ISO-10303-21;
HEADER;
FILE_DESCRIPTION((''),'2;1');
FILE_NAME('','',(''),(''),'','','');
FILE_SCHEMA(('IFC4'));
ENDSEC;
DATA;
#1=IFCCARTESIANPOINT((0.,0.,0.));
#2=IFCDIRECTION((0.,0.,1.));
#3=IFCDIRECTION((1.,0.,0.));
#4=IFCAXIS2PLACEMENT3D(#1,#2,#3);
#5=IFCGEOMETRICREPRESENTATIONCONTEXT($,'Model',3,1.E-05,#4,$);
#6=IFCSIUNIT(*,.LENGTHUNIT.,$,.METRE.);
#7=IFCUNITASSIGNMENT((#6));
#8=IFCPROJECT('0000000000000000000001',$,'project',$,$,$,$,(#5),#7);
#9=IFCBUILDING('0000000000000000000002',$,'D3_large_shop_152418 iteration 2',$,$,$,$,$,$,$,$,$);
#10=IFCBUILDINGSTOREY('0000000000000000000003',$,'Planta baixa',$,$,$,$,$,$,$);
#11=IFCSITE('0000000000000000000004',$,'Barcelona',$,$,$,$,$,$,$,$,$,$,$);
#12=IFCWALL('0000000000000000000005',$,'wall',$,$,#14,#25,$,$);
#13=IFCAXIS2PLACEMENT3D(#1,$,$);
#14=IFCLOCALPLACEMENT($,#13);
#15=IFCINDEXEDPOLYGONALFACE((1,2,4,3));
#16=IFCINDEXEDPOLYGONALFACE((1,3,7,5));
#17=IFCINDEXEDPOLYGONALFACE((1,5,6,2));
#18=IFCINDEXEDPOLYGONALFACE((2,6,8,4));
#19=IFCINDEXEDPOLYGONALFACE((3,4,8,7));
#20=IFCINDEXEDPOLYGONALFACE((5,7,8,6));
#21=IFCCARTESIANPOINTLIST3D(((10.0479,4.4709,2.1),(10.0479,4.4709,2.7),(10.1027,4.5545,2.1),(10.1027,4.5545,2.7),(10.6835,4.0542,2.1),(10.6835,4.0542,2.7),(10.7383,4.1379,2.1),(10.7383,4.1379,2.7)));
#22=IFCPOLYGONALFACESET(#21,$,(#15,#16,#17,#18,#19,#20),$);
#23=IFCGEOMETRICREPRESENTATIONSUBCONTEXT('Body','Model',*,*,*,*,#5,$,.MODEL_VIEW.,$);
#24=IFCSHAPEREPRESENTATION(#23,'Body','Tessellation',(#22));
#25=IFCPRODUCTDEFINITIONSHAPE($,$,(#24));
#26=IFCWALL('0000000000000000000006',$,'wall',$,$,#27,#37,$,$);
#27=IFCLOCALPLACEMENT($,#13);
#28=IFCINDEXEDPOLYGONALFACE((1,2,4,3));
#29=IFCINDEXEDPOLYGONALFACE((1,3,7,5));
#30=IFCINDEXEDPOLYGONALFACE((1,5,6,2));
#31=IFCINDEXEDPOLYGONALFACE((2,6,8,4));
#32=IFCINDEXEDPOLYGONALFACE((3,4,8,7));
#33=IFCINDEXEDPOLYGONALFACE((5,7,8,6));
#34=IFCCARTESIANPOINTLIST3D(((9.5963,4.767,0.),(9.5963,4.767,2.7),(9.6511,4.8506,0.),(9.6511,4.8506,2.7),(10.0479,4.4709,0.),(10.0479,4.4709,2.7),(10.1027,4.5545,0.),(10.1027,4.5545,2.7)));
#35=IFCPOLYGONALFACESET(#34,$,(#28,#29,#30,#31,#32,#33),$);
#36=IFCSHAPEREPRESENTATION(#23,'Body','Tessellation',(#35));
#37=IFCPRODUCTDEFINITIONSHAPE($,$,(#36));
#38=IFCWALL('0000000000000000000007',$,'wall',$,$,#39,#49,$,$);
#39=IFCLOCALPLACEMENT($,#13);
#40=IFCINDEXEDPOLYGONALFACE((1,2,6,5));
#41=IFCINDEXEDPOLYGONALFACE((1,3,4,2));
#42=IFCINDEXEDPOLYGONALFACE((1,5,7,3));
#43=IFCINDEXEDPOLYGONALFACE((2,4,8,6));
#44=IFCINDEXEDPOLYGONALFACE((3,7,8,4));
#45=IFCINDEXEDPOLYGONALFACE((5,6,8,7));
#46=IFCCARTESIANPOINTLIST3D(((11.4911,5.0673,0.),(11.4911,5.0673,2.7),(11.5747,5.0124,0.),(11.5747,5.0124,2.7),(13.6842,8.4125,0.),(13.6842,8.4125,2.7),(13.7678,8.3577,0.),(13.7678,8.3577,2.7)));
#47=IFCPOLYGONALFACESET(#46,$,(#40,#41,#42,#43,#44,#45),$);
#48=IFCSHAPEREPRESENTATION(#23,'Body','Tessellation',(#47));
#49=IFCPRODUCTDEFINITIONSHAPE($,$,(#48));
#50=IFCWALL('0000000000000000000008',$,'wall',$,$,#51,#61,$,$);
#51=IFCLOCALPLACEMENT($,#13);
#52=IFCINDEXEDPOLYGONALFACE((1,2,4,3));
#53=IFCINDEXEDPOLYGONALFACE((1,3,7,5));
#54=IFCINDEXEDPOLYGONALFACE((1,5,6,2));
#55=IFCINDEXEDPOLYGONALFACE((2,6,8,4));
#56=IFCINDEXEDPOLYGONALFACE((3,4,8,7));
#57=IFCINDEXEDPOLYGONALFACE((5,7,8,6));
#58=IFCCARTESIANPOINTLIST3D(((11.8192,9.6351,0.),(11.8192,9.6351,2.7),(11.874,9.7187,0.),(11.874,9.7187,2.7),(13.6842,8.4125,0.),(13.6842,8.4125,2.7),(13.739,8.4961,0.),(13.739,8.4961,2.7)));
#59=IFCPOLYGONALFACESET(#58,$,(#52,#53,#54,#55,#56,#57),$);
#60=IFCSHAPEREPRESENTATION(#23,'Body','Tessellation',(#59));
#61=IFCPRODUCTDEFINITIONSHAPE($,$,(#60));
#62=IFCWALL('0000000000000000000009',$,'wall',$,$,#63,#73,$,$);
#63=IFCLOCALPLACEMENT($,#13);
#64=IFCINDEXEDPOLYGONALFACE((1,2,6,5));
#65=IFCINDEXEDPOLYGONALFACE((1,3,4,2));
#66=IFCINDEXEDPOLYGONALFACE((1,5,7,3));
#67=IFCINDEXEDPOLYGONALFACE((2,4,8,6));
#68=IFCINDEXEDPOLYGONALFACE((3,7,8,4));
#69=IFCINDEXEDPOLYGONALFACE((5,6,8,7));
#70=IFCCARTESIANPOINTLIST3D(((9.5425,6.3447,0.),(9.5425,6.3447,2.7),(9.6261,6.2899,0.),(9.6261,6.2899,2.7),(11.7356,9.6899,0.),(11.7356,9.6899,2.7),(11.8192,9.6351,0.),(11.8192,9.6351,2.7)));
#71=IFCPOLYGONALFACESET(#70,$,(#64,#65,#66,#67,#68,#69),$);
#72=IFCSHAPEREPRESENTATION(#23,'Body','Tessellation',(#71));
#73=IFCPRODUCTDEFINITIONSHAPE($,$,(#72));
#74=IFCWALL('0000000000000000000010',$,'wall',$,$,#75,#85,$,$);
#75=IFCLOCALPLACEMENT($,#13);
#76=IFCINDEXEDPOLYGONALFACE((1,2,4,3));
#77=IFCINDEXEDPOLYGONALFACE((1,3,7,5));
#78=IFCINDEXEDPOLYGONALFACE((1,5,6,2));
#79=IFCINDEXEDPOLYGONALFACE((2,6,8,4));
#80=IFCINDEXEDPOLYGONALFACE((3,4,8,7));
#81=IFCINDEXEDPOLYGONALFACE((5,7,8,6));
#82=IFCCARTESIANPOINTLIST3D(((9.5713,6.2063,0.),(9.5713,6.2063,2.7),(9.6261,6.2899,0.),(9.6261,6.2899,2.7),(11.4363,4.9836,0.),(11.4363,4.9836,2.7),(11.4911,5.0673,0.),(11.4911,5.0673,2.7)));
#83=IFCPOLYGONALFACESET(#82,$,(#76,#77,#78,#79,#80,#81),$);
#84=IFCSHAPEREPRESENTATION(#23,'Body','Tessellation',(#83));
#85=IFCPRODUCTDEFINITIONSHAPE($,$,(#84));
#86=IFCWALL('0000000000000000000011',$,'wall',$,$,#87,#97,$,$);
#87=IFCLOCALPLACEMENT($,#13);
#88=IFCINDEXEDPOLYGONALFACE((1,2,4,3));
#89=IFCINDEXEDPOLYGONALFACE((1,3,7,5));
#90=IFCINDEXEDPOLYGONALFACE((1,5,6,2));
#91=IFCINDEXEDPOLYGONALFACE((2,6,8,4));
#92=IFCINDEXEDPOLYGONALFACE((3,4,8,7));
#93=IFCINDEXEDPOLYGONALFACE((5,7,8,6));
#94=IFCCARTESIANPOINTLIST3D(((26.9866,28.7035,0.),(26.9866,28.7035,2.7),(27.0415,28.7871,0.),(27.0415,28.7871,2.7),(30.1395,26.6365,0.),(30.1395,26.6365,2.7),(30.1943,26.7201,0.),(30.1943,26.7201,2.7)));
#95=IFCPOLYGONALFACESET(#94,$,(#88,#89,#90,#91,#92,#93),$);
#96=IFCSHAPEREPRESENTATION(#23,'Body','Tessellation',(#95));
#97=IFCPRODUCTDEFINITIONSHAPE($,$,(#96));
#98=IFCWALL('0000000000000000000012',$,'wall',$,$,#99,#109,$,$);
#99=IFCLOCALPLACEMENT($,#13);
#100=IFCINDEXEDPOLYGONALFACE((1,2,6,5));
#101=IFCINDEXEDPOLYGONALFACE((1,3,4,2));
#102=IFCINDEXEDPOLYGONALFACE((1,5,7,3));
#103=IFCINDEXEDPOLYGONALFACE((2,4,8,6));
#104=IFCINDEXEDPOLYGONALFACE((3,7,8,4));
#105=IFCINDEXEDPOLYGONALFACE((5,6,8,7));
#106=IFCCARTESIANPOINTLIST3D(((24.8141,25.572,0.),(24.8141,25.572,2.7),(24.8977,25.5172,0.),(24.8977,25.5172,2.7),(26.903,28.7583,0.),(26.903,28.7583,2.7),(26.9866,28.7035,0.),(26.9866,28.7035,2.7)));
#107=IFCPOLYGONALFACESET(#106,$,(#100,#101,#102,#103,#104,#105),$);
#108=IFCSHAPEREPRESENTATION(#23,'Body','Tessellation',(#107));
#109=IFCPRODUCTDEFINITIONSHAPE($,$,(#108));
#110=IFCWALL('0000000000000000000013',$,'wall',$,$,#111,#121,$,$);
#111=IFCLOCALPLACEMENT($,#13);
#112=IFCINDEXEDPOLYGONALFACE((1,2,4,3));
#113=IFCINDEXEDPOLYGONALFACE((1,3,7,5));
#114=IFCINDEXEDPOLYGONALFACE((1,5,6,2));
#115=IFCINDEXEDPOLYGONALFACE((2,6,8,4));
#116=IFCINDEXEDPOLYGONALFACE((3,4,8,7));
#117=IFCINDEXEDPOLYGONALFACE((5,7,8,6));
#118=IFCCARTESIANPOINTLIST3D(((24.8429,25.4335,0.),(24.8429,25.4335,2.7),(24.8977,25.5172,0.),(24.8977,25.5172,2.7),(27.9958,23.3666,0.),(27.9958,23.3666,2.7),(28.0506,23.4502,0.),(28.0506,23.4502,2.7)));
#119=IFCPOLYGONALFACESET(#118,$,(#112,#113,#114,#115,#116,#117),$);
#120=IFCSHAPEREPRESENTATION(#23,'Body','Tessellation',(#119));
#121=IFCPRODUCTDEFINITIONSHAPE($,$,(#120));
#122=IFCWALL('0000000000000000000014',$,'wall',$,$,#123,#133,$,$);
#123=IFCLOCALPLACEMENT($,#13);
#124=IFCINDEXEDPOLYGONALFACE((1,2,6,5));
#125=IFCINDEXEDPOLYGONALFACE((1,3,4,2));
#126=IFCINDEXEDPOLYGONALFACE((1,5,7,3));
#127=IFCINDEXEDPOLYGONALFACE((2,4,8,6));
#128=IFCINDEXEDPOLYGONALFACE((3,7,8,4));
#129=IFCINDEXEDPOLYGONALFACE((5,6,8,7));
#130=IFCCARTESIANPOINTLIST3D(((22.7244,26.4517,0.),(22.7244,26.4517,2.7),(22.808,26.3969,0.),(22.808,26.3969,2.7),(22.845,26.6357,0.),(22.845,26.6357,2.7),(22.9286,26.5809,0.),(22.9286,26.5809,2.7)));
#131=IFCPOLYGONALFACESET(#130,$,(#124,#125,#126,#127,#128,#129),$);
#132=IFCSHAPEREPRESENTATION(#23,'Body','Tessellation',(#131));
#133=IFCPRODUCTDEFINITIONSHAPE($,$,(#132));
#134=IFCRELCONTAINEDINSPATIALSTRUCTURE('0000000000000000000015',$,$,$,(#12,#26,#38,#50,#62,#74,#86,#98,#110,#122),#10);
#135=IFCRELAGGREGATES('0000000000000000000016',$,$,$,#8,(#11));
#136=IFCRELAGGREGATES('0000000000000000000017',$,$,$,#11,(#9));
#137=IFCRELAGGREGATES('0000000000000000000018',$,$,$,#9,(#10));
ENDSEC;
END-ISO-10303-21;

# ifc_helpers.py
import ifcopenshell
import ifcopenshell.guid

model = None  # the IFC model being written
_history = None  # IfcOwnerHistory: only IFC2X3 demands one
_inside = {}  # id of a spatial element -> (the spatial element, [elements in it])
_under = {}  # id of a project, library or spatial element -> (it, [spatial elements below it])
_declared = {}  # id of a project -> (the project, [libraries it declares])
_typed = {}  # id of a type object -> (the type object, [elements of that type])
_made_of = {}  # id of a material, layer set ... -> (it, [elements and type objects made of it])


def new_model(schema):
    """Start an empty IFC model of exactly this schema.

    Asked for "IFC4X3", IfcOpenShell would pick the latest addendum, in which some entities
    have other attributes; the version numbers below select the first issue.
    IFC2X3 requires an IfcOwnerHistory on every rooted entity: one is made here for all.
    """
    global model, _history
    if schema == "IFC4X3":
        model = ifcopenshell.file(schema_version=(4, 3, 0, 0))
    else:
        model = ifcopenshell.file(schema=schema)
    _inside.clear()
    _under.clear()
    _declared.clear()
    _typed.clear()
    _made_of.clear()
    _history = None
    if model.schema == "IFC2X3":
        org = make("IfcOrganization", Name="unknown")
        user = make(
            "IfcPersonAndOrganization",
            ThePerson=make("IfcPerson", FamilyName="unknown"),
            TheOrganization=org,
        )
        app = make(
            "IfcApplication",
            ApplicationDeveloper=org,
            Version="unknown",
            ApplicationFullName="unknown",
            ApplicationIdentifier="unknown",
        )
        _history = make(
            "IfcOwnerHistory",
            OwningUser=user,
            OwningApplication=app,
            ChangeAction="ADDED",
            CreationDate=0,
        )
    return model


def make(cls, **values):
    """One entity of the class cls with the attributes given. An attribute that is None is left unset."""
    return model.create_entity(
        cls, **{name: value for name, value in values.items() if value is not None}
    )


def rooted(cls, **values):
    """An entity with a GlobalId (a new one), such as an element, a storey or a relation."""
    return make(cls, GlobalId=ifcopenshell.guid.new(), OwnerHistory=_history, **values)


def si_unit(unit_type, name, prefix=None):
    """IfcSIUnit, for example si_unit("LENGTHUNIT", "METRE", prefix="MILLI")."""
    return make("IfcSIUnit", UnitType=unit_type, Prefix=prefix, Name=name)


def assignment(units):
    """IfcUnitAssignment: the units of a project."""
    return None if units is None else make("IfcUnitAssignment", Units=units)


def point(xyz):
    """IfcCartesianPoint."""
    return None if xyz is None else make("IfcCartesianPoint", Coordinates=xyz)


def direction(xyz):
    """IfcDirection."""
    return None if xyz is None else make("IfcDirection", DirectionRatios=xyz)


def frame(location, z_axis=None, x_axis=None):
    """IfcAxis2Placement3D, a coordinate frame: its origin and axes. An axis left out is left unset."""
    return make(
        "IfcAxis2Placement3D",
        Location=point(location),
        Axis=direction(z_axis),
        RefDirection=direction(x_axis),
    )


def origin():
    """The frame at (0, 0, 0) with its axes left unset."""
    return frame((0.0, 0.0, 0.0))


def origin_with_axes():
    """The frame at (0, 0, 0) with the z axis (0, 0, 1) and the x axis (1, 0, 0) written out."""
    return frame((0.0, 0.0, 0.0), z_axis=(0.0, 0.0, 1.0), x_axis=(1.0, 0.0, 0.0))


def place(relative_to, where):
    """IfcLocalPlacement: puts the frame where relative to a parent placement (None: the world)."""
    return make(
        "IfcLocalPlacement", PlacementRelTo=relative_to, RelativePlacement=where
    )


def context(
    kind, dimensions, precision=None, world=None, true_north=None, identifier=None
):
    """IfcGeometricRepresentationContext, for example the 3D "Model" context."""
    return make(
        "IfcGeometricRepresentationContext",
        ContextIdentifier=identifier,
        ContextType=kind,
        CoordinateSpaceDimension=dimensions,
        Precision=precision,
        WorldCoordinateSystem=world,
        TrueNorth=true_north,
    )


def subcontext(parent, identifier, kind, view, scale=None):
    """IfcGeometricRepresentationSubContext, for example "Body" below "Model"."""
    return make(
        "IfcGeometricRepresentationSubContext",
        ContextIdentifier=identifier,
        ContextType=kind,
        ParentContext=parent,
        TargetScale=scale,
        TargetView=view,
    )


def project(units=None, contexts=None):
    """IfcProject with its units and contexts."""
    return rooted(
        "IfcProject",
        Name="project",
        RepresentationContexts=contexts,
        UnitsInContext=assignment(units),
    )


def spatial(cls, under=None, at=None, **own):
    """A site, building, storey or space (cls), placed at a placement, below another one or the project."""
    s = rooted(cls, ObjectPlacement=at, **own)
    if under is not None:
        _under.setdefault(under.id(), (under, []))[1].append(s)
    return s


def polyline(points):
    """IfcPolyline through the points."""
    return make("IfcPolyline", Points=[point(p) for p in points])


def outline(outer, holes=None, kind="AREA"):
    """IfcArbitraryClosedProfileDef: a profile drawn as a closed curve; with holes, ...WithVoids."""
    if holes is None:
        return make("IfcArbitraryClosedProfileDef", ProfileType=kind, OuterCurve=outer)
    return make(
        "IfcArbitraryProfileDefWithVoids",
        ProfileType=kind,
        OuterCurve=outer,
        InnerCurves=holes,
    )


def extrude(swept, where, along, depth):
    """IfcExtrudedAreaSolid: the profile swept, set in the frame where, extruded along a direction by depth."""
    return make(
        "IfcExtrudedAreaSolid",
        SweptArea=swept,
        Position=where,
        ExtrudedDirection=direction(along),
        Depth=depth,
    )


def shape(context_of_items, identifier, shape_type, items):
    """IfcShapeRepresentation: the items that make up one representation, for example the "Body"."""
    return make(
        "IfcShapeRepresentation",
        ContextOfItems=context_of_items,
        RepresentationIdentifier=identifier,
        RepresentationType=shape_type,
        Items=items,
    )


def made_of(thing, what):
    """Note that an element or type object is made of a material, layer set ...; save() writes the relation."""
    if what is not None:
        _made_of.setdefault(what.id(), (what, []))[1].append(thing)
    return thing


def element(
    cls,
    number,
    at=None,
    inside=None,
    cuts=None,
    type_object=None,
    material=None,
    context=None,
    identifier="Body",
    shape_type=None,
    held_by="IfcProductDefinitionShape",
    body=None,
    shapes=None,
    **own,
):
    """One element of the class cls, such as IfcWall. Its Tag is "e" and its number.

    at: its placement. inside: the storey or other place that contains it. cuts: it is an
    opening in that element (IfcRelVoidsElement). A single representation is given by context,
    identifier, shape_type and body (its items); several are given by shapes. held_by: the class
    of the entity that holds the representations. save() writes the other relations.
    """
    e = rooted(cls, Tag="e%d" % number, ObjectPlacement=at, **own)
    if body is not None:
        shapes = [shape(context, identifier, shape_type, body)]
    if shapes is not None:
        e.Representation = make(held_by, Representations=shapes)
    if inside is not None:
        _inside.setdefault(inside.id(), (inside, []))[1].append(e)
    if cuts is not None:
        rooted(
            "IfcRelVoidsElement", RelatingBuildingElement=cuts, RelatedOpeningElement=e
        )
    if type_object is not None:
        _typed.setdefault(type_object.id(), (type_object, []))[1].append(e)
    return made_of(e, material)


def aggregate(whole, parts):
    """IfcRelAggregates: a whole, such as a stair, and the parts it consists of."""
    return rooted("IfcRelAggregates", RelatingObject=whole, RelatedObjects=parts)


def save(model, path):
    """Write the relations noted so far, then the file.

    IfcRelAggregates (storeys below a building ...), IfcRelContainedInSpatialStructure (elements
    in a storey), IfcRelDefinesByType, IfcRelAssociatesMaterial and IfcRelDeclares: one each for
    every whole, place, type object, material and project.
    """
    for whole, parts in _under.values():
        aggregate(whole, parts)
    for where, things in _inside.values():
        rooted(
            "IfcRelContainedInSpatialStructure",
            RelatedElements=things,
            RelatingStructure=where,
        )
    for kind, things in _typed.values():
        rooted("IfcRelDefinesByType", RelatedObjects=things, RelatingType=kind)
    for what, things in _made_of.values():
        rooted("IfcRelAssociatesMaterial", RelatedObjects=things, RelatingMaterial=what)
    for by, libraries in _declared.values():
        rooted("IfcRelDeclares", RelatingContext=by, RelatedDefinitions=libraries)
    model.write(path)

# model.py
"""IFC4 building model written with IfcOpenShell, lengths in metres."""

from ifc_helpers import new_model, si_unit, frame, origin, origin_with_axes, place, context, subcontext, project, spatial, polyline, outline, extrude, element, save


model = new_model("IFC4")

# Units and contexts
model_context = context("Model", 3, precision=1e-05, world=origin_with_axes())
body_context = subcontext(model_context, "Body", "Model", "MODEL_VIEW")
ifc_project = project(units=[si_unit("LENGTHUNIT", "METRE")], contexts=[model_context])

# Site, building, storey
site = spatial("IfcSite", under=ifc_project, Name="Barcelona")
building = spatial("IfcBuilding", under=site, Name="D3_large_shop_152418 iteration 2")
storey = spatial("IfcBuildingStorey", under=building, Name="Planta baixa")

# Walls
wall_1_placement = place(None, origin_with_axes())
element("IfcWall", 1, at=wall_1_placement, inside=storey, Name="wall", context=body_context, shape_type="SweptSolid", body=[
    extrude(outline(polyline([(10.6835, 4.0542), (10.0479, 4.4709), (10.1027, 4.5545), (10.7383, 4.1379), (10.6835, 4.0542)])), frame((0.0, 0.0, 2.1)), (0.0, 0.0, 1.0), 0.6),
])
wall_2_placement = place(None, origin_with_axes())
element("IfcWall", 2, at=wall_2_placement, inside=storey, Name="wall", context=body_context, shape_type="SweptSolid", body=[
    extrude(outline(polyline([(10.0479, 4.4709), (9.5963, 4.767), (9.6511, 4.8506), (10.1027, 4.5545), (10.0479, 4.4709)])), origin(), (0.0, 0.0, 1.0), 2.7),
])
wall_3_placement = place(None, origin_with_axes())
element("IfcWall", 3, at=wall_3_placement, inside=storey, Name="wall", context=body_context, shape_type="SweptSolid", body=[
    extrude(outline(polyline([(11.4911, 5.0673), (13.6842, 8.4125), (13.7678, 8.3577), (11.5747, 5.0124), (11.4911, 5.0673)])), origin(), (0.0, 0.0, 1.0), 2.7),
])
wall_4_placement = place(None, origin_with_axes())
element("IfcWall", 4, at=wall_4_placement, inside=storey, Name="wall", context=body_context, shape_type="SweptSolid", body=[
    extrude(outline(polyline([(13.6842, 8.4125), (11.8192, 9.6351), (11.874, 9.7187), (13.739, 8.4961), (13.6842, 8.4125)])), origin(), (0.0, 0.0, 1.0), 2.7),
])
wall_5_placement = place(None, origin_with_axes())
element("IfcWall", 5, at=wall_5_placement, inside=storey, Name="wall", context=body_context, shape_type="SweptSolid", body=[
    extrude(outline(polyline([(11.8192, 9.6351), (9.6261, 6.2899), (9.5425, 6.3447), (11.7356, 9.6899), (11.8192, 9.6351)])), origin(), (0.0, 0.0, 1.0), 2.7),
])
wall_6_placement = place(None, origin_with_axes())
element("IfcWall", 6, at=wall_6_placement, inside=storey, Name="wall", context=body_context, shape_type="SweptSolid", body=[
    extrude(outline(polyline([(9.6261, 6.2899), (11.4911, 5.0673), (11.4363, 4.9836), (9.5713, 6.2063), (9.6261, 6.2899)])), origin(), (0.0, 0.0, 1.0), 2.7),
])
wall_7_placement = place(None, origin_with_axes())
element("IfcWall", 7, at=wall_7_placement, inside=storey, Name="wall", context=body_context, shape_type="SweptSolid", body=[
    extrude(outline(polyline([(30.1395, 26.6365), (26.9866, 28.7035), (27.0415, 28.7871), (30.1943, 26.7201), (30.1395, 26.6365)])), origin(), (0.0, 0.0, 1.0), 2.7),
])
wall_8_placement = place(None, origin_with_axes())
element("IfcWall", 8, at=wall_8_placement, inside=storey, Name="wall", context=body_context, shape_type="SweptSolid", body=[
    extrude(outline(polyline([(26.9866, 28.7035), (24.8977, 25.5172), (24.8141, 25.572), (26.903, 28.7583), (26.9866, 28.7035)])), origin(), (0.0, 0.0, 1.0), 2.7),
])
wall_9_placement = place(None, origin_with_axes())
element("IfcWall", 9, at=wall_9_placement, inside=storey, Name="wall", context=body_context, shape_type="SweptSolid", body=[
    extrude(outline(polyline([(24.8977, 25.5172), (28.0506, 23.4502), (27.9958, 23.3666), (24.8429, 25.4335), (24.8977, 25.5172)])), origin(), (0.0, 0.0, 1.0), 2.7),
])
wall_10_placement = place(None, origin_with_axes())
element("IfcWall", 10, at=wall_10_placement, inside=storey, Name="wall", context=body_context, shape_type="SweptSolid", body=[
    extrude(outline(polyline([(22.9286, 26.5809), (22.808, 26.3969), (22.7244, 26.4517), (22.845, 26.6357), (22.9286, 26.5809)])), origin(), (0.0, 0.0, 1.0), 2.7),
])

save(model, "model.ifc")
